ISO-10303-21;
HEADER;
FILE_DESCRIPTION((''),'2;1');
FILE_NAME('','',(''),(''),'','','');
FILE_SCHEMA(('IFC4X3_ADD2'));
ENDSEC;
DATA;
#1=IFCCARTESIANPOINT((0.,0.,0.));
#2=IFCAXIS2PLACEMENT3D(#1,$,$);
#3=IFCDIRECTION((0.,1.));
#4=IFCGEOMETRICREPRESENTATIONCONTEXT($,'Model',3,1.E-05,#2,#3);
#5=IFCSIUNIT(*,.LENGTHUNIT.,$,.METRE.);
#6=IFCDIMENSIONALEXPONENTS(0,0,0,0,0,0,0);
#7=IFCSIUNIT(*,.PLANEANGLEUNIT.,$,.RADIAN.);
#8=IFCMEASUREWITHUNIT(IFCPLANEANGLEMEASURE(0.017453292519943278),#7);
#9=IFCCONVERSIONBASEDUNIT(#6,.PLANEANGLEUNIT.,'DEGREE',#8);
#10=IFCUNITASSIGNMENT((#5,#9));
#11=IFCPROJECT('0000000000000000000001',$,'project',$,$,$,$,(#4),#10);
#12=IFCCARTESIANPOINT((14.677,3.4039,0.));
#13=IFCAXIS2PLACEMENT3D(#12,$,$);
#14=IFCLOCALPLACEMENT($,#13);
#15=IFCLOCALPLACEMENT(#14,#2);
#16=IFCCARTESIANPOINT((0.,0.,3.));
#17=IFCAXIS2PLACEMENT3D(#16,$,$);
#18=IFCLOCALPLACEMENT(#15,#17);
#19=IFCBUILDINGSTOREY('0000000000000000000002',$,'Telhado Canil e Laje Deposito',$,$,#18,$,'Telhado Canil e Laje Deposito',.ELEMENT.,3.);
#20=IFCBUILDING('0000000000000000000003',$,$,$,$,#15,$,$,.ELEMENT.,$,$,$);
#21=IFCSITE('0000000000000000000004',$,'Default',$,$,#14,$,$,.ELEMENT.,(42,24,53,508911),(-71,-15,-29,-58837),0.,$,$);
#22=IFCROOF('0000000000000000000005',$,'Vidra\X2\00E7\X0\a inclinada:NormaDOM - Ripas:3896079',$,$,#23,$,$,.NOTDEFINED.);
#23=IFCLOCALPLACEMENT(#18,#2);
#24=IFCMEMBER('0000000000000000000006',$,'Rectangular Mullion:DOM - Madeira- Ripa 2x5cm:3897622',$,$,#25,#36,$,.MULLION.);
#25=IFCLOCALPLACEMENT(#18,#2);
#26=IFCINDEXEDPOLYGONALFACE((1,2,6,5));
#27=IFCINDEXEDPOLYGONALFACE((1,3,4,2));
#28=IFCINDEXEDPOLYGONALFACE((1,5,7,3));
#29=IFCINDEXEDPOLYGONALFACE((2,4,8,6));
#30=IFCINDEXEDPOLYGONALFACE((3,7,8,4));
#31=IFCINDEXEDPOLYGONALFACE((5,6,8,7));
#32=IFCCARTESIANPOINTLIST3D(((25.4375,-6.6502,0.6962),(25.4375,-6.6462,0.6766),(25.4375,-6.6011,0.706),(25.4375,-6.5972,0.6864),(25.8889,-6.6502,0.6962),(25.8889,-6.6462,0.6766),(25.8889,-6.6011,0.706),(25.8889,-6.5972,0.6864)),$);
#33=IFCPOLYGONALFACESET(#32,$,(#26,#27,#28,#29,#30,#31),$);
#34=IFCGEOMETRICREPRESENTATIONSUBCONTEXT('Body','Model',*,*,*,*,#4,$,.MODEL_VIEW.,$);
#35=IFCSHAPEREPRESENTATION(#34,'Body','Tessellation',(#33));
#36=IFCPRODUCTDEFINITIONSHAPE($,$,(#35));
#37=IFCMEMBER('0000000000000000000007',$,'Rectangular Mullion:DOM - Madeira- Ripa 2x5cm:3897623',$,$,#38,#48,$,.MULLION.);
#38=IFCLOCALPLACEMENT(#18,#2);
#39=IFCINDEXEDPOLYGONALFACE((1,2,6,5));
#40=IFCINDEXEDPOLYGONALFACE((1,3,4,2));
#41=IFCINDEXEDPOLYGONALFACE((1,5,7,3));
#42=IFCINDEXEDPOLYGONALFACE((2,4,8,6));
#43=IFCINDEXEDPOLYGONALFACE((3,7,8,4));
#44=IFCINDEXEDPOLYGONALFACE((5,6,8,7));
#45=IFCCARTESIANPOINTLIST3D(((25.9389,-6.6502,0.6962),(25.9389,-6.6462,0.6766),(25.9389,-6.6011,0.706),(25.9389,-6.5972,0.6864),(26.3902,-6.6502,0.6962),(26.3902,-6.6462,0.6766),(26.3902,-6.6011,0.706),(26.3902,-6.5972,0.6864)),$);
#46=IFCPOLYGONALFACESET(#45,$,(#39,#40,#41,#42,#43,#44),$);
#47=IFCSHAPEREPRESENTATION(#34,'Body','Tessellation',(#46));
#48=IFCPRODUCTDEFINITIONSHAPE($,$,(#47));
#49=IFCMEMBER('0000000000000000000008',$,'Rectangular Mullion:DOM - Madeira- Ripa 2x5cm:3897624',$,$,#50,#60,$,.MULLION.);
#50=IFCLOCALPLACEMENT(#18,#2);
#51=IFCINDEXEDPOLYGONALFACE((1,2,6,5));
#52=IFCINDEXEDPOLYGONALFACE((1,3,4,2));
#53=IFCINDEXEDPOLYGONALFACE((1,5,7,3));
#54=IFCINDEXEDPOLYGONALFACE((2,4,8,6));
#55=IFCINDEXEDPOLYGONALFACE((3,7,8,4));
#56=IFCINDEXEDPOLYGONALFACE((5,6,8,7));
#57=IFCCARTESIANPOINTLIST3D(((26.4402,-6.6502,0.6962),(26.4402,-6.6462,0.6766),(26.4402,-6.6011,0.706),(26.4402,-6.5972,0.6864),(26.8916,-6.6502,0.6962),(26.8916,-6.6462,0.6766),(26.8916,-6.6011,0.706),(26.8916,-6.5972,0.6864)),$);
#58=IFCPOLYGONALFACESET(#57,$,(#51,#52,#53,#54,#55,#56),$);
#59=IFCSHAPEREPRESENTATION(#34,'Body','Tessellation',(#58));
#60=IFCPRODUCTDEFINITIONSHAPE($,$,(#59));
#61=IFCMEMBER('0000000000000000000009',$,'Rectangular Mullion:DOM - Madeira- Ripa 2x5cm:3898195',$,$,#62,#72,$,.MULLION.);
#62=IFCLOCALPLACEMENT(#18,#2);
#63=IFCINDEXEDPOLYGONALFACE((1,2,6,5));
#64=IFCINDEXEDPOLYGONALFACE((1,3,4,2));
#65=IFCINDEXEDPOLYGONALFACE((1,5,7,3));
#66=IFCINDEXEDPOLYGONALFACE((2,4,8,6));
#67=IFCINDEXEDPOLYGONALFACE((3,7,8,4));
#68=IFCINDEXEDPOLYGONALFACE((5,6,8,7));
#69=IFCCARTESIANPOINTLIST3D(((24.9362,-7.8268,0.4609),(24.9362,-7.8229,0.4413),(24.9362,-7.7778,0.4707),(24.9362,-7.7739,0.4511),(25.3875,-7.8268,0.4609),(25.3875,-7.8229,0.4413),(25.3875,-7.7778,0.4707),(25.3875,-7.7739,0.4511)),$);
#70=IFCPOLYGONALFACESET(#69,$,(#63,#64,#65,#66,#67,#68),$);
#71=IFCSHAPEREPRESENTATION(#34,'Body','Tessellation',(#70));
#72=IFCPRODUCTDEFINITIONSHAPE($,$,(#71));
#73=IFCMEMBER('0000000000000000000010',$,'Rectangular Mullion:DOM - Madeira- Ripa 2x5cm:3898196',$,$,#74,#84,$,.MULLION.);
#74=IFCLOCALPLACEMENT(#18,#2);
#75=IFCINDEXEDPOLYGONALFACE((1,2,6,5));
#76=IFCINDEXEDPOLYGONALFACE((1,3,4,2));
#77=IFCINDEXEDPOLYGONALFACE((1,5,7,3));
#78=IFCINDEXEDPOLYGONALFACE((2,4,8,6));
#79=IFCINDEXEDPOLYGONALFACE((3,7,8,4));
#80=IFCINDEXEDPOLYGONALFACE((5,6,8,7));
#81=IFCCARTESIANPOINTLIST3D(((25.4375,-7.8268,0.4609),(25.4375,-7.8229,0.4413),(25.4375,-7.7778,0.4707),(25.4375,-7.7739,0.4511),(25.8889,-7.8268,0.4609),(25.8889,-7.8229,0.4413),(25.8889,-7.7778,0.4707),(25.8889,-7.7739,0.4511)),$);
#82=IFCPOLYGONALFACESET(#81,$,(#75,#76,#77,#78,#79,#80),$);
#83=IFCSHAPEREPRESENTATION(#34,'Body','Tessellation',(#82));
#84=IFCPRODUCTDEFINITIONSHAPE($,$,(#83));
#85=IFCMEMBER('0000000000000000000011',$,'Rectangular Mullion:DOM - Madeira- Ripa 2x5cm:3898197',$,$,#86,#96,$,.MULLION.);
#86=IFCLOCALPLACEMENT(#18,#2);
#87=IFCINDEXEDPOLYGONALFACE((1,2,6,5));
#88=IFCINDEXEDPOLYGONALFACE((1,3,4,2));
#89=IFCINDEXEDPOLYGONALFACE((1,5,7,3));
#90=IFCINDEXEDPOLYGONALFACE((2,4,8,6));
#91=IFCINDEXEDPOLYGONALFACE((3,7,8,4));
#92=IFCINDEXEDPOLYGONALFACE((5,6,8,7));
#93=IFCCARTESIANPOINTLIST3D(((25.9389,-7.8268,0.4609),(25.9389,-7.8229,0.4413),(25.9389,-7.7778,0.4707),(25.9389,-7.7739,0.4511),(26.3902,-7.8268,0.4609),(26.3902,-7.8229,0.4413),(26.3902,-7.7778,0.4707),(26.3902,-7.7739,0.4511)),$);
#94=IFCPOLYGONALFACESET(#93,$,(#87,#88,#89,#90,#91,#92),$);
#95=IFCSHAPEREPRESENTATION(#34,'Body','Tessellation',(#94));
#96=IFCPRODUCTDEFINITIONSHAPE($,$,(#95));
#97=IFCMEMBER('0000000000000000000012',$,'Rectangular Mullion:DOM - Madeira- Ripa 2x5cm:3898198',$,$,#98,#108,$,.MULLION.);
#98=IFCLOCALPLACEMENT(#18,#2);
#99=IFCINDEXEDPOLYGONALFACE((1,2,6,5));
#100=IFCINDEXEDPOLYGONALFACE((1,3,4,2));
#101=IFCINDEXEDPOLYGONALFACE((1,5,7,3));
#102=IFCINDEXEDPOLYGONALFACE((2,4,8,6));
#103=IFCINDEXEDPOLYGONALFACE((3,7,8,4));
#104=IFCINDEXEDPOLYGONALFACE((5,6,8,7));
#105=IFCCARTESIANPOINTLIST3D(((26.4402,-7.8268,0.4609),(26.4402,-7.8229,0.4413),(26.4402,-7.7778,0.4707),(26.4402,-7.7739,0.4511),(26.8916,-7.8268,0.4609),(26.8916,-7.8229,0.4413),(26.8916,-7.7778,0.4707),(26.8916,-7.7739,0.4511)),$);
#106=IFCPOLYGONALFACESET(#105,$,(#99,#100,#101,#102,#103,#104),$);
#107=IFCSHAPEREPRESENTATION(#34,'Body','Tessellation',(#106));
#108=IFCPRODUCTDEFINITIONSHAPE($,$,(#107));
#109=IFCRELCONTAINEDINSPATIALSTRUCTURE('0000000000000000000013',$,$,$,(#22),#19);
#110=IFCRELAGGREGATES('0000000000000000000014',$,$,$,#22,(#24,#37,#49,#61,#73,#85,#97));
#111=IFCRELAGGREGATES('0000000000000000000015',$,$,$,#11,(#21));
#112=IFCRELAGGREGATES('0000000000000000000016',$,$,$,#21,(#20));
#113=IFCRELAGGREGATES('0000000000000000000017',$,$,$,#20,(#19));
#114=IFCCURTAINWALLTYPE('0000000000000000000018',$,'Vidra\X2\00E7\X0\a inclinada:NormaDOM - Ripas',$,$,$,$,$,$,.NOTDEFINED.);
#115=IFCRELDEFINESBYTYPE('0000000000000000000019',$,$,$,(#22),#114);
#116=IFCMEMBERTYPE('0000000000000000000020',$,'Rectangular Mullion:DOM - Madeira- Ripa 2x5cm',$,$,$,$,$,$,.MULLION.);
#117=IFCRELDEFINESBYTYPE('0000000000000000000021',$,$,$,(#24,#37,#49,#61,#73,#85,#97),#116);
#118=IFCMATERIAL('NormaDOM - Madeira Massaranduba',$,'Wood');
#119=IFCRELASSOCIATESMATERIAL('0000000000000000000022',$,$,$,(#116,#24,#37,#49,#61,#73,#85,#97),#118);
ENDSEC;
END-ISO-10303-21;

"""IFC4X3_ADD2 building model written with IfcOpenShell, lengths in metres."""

from ifc_helpers import new_model, entity, si_unit, converted_unit, direction, frame, origin, origin_2d_with_axis, place, context, subcontext, project, spatial, rectangle, extrude, source, transform, mapped, material, material_profile, profile_set, profile_usage, type_object, type_shapes, element, aggregate, save


model = new_model("IFC4X3_ADD2")

# Units and contexts
model_context = context("Model", 3, precision=1e-05, world=origin(), true_north=direction((0.0, 1.0)))
body_context = subcontext(model_context, "Body", "Model", "MODEL_VIEW")
ifc_project = project(units=[si_unit("LENGTHUNIT", "METRE"), converted_unit("PLANEANGLEUNIT", "DEGREE", entity("IfcPlaneAngleMeasure", 0.017453292519943278), si_unit("PLANEANGLEUNIT", "RADIAN"), dimensions=[0, 0, 0, 0, 0, 0, 0])], contexts=[model_context])

# Site, building, storey
site_placement = place(None, frame((14.677, 3.4039, 0.0)))
site = spatial("IfcSite", under=ifc_project, at=site_placement, Name="Default", CompositionType="ELEMENT", RefLatitude=(42, 24, 53, 508911), RefLongitude=(-71, -15, -29, -58837), RefElevation=0.0)
building_placement = place(site_placement, origin())
building = spatial("IfcBuilding", under=site, at=building_placement, CompositionType="ELEMENT")
storey_placement = place(building_placement, frame((0.0, 0.0, 3.0)))
storey = spatial("IfcBuildingStorey", under=building, at=storey_placement, Name="Telhado Canil e Laje Deposito", LongName="Telhado Canil e Laje Deposito", CompositionType="ELEMENT", Elevation=3.0)

# Roof, members
ifc_material = material(Name="NormaDOM - Madeira Massaranduba", Category="Wood")
ifc_material_profile_1 = material_profile(ifc_material, rectangle(XDim=0.05, YDim=0.02, at=origin_2d_with_axis()), Name="DOM - Madeira- Ripa 2x5cm")
ifc_profile_set_1 = profile_set([ifc_material_profile_1], Name="DOM - Madeira- Ripa 2x5cm")
ifc_profile_usage_1 = profile_usage(ifc_profile_set_1)
curtain_wall_type_1 = type_object("IfcCurtainWallType", Name="Vidraça inclinada:NormaDOM - Ripas", PredefinedType="NOTDEFINED")
roof_1_placement = place(storey_placement, frame((0.0, 0.0, -3.0)))
roof_1 = element("IfcRoof", 1, at=roof_1_placement, inside=storey, type_object=curtain_wall_type_1, Name="Vidraça inclinada:NormaDOM - Ripas:3896079", PredefinedType="NOTDEFINED")
member_type_1 = type_object("IfcMemberType", Name="Rectangular Mullion:DOM - Madeira- Ripa 2x5cm", PredefinedType="MULLION", material=ifc_profile_set_1)
shared_shape_1 = source(origin(), body_context, "Body", "SweptSolid", [
    extrude(rectangle(XDim=0.05, YDim=0.02, at=origin_2d_with_axis()), frame((0.025, 0.01, -0.4514), z_axis=(0.0, 0.0, 1.0), x_axis=(-1.0, 0.0, 0.0)), (0.0, 0.0, 1.0), 0.4514),
])
type_shapes(member_type_1, [shared_shape_1])
member_1_placement = place(roof_1_placement, frame((25.4375, -6.6502, 3.6962), z_axis=(-1.0, 0.0, 0.0), x_axis=(0.0, 0.980581, 0.196116)))
member_1 = element("IfcMember", 2, at=member_1_placement, type_object=member_type_1, material=ifc_profile_usage_1, Name="Rectangular Mullion:DOM - Madeira- Ripa 2x5cm:3897622", PredefinedType="MULLION", context=body_context, shape_type="MappedRepresentation", body=[
    mapped(shared_shape_1, transform((0.0, 0.0, 0.0), scale=1.0)),
])
member_2_placement = place(roof_1_placement, frame((25.9389, -6.6502, 3.6962), z_axis=(-1.0, 0.0, 0.0), x_axis=(0.0, 0.980581, 0.196116)))
member_2 = element("IfcMember", 3, at=member_2_placement, type_object=member_type_1, material=ifc_profile_usage_1, Name="Rectangular Mullion:DOM - Madeira- Ripa 2x5cm:3897623", PredefinedType="MULLION", context=body_context, shape_type="MappedRepresentation", body=[
    mapped(shared_shape_1, transform((0.0, 0.0, 0.0), scale=1.0)),
])
member_3_placement = place(roof_1_placement, frame((26.4402, -6.6502, 3.6962), z_axis=(-1.0, 0.0, 0.0), x_axis=(0.0, 0.980581, 0.196116)))
member_3 = element("IfcMember", 4, at=member_3_placement, type_object=member_type_1, material=ifc_profile_usage_1, Name="Rectangular Mullion:DOM - Madeira- Ripa 2x5cm:3897624", PredefinedType="MULLION", context=body_context, shape_type="MappedRepresentation", body=[
    mapped(shared_shape_1, transform((0.0, 0.0, 0.0), scale=1.0)),
])
member_4_placement = place(roof_1_placement, frame((24.9362, -7.8268, 3.4609), z_axis=(-1.0, 0.0, 0.0), x_axis=(0.0, 0.980581, 0.196116)))
member_4 = element("IfcMember", 5, at=member_4_placement, type_object=member_type_1, material=ifc_profile_usage_1, Name="Rectangular Mullion:DOM - Madeira- Ripa 2x5cm:3898195", PredefinedType="MULLION", context=body_context, shape_type="MappedRepresentation", body=[
    mapped(shared_shape_1, transform((0.0, 0.0, 0.0), scale=1.0)),
])
member_5_placement = place(roof_1_placement, frame((25.4375, -7.8268, 3.4609), z_axis=(-1.0, 0.0, 0.0), x_axis=(0.0, 0.980581, 0.196116)))
member_5 = element("IfcMember", 6, at=member_5_placement, type_object=member_type_1, material=ifc_profile_usage_1, Name="Rectangular Mullion:DOM - Madeira- Ripa 2x5cm:3898196", PredefinedType="MULLION", context=body_context, shape_type="MappedRepresentation", body=[
    mapped(shared_shape_1, transform((0.0, 0.0, 0.0), scale=1.0)),
])
member_6_placement = place(roof_1_placement, frame((25.9389, -7.8268, 3.4609), z_axis=(-1.0, 0.0, 0.0), x_axis=(0.0, 0.980581, 0.196116)))
member_6 = element("IfcMember", 7, at=member_6_placement, type_object=member_type_1, material=ifc_profile_usage_1, Name="Rectangular Mullion:DOM - Madeira- Ripa 2x5cm:3898197", PredefinedType="MULLION", context=body_context, shape_type="MappedRepresentation", body=[
    mapped(shared_shape_1, transform((0.0, 0.0, 0.0), scale=1.0)),
])
member_7_placement = place(roof_1_placement, frame((26.4402, -7.8268, 3.4609), z_axis=(-1.0, 0.0, 0.0), x_axis=(0.0, 0.980581, 0.196116)))
member_7 = element("IfcMember", 8, at=member_7_placement, type_object=member_type_1, material=ifc_profile_usage_1, Name="Rectangular Mullion:DOM - Madeira- Ripa 2x5cm:3898198", PredefinedType="MULLION", context=body_context, shape_type="MappedRepresentation", body=[
    mapped(shared_shape_1, transform((0.0, 0.0, 0.0), scale=1.0)),
])
aggregate(roof_1, [member_1, member_2, member_3, member_4, member_5, member_6, member_7])

save(model, "model.ifc")
